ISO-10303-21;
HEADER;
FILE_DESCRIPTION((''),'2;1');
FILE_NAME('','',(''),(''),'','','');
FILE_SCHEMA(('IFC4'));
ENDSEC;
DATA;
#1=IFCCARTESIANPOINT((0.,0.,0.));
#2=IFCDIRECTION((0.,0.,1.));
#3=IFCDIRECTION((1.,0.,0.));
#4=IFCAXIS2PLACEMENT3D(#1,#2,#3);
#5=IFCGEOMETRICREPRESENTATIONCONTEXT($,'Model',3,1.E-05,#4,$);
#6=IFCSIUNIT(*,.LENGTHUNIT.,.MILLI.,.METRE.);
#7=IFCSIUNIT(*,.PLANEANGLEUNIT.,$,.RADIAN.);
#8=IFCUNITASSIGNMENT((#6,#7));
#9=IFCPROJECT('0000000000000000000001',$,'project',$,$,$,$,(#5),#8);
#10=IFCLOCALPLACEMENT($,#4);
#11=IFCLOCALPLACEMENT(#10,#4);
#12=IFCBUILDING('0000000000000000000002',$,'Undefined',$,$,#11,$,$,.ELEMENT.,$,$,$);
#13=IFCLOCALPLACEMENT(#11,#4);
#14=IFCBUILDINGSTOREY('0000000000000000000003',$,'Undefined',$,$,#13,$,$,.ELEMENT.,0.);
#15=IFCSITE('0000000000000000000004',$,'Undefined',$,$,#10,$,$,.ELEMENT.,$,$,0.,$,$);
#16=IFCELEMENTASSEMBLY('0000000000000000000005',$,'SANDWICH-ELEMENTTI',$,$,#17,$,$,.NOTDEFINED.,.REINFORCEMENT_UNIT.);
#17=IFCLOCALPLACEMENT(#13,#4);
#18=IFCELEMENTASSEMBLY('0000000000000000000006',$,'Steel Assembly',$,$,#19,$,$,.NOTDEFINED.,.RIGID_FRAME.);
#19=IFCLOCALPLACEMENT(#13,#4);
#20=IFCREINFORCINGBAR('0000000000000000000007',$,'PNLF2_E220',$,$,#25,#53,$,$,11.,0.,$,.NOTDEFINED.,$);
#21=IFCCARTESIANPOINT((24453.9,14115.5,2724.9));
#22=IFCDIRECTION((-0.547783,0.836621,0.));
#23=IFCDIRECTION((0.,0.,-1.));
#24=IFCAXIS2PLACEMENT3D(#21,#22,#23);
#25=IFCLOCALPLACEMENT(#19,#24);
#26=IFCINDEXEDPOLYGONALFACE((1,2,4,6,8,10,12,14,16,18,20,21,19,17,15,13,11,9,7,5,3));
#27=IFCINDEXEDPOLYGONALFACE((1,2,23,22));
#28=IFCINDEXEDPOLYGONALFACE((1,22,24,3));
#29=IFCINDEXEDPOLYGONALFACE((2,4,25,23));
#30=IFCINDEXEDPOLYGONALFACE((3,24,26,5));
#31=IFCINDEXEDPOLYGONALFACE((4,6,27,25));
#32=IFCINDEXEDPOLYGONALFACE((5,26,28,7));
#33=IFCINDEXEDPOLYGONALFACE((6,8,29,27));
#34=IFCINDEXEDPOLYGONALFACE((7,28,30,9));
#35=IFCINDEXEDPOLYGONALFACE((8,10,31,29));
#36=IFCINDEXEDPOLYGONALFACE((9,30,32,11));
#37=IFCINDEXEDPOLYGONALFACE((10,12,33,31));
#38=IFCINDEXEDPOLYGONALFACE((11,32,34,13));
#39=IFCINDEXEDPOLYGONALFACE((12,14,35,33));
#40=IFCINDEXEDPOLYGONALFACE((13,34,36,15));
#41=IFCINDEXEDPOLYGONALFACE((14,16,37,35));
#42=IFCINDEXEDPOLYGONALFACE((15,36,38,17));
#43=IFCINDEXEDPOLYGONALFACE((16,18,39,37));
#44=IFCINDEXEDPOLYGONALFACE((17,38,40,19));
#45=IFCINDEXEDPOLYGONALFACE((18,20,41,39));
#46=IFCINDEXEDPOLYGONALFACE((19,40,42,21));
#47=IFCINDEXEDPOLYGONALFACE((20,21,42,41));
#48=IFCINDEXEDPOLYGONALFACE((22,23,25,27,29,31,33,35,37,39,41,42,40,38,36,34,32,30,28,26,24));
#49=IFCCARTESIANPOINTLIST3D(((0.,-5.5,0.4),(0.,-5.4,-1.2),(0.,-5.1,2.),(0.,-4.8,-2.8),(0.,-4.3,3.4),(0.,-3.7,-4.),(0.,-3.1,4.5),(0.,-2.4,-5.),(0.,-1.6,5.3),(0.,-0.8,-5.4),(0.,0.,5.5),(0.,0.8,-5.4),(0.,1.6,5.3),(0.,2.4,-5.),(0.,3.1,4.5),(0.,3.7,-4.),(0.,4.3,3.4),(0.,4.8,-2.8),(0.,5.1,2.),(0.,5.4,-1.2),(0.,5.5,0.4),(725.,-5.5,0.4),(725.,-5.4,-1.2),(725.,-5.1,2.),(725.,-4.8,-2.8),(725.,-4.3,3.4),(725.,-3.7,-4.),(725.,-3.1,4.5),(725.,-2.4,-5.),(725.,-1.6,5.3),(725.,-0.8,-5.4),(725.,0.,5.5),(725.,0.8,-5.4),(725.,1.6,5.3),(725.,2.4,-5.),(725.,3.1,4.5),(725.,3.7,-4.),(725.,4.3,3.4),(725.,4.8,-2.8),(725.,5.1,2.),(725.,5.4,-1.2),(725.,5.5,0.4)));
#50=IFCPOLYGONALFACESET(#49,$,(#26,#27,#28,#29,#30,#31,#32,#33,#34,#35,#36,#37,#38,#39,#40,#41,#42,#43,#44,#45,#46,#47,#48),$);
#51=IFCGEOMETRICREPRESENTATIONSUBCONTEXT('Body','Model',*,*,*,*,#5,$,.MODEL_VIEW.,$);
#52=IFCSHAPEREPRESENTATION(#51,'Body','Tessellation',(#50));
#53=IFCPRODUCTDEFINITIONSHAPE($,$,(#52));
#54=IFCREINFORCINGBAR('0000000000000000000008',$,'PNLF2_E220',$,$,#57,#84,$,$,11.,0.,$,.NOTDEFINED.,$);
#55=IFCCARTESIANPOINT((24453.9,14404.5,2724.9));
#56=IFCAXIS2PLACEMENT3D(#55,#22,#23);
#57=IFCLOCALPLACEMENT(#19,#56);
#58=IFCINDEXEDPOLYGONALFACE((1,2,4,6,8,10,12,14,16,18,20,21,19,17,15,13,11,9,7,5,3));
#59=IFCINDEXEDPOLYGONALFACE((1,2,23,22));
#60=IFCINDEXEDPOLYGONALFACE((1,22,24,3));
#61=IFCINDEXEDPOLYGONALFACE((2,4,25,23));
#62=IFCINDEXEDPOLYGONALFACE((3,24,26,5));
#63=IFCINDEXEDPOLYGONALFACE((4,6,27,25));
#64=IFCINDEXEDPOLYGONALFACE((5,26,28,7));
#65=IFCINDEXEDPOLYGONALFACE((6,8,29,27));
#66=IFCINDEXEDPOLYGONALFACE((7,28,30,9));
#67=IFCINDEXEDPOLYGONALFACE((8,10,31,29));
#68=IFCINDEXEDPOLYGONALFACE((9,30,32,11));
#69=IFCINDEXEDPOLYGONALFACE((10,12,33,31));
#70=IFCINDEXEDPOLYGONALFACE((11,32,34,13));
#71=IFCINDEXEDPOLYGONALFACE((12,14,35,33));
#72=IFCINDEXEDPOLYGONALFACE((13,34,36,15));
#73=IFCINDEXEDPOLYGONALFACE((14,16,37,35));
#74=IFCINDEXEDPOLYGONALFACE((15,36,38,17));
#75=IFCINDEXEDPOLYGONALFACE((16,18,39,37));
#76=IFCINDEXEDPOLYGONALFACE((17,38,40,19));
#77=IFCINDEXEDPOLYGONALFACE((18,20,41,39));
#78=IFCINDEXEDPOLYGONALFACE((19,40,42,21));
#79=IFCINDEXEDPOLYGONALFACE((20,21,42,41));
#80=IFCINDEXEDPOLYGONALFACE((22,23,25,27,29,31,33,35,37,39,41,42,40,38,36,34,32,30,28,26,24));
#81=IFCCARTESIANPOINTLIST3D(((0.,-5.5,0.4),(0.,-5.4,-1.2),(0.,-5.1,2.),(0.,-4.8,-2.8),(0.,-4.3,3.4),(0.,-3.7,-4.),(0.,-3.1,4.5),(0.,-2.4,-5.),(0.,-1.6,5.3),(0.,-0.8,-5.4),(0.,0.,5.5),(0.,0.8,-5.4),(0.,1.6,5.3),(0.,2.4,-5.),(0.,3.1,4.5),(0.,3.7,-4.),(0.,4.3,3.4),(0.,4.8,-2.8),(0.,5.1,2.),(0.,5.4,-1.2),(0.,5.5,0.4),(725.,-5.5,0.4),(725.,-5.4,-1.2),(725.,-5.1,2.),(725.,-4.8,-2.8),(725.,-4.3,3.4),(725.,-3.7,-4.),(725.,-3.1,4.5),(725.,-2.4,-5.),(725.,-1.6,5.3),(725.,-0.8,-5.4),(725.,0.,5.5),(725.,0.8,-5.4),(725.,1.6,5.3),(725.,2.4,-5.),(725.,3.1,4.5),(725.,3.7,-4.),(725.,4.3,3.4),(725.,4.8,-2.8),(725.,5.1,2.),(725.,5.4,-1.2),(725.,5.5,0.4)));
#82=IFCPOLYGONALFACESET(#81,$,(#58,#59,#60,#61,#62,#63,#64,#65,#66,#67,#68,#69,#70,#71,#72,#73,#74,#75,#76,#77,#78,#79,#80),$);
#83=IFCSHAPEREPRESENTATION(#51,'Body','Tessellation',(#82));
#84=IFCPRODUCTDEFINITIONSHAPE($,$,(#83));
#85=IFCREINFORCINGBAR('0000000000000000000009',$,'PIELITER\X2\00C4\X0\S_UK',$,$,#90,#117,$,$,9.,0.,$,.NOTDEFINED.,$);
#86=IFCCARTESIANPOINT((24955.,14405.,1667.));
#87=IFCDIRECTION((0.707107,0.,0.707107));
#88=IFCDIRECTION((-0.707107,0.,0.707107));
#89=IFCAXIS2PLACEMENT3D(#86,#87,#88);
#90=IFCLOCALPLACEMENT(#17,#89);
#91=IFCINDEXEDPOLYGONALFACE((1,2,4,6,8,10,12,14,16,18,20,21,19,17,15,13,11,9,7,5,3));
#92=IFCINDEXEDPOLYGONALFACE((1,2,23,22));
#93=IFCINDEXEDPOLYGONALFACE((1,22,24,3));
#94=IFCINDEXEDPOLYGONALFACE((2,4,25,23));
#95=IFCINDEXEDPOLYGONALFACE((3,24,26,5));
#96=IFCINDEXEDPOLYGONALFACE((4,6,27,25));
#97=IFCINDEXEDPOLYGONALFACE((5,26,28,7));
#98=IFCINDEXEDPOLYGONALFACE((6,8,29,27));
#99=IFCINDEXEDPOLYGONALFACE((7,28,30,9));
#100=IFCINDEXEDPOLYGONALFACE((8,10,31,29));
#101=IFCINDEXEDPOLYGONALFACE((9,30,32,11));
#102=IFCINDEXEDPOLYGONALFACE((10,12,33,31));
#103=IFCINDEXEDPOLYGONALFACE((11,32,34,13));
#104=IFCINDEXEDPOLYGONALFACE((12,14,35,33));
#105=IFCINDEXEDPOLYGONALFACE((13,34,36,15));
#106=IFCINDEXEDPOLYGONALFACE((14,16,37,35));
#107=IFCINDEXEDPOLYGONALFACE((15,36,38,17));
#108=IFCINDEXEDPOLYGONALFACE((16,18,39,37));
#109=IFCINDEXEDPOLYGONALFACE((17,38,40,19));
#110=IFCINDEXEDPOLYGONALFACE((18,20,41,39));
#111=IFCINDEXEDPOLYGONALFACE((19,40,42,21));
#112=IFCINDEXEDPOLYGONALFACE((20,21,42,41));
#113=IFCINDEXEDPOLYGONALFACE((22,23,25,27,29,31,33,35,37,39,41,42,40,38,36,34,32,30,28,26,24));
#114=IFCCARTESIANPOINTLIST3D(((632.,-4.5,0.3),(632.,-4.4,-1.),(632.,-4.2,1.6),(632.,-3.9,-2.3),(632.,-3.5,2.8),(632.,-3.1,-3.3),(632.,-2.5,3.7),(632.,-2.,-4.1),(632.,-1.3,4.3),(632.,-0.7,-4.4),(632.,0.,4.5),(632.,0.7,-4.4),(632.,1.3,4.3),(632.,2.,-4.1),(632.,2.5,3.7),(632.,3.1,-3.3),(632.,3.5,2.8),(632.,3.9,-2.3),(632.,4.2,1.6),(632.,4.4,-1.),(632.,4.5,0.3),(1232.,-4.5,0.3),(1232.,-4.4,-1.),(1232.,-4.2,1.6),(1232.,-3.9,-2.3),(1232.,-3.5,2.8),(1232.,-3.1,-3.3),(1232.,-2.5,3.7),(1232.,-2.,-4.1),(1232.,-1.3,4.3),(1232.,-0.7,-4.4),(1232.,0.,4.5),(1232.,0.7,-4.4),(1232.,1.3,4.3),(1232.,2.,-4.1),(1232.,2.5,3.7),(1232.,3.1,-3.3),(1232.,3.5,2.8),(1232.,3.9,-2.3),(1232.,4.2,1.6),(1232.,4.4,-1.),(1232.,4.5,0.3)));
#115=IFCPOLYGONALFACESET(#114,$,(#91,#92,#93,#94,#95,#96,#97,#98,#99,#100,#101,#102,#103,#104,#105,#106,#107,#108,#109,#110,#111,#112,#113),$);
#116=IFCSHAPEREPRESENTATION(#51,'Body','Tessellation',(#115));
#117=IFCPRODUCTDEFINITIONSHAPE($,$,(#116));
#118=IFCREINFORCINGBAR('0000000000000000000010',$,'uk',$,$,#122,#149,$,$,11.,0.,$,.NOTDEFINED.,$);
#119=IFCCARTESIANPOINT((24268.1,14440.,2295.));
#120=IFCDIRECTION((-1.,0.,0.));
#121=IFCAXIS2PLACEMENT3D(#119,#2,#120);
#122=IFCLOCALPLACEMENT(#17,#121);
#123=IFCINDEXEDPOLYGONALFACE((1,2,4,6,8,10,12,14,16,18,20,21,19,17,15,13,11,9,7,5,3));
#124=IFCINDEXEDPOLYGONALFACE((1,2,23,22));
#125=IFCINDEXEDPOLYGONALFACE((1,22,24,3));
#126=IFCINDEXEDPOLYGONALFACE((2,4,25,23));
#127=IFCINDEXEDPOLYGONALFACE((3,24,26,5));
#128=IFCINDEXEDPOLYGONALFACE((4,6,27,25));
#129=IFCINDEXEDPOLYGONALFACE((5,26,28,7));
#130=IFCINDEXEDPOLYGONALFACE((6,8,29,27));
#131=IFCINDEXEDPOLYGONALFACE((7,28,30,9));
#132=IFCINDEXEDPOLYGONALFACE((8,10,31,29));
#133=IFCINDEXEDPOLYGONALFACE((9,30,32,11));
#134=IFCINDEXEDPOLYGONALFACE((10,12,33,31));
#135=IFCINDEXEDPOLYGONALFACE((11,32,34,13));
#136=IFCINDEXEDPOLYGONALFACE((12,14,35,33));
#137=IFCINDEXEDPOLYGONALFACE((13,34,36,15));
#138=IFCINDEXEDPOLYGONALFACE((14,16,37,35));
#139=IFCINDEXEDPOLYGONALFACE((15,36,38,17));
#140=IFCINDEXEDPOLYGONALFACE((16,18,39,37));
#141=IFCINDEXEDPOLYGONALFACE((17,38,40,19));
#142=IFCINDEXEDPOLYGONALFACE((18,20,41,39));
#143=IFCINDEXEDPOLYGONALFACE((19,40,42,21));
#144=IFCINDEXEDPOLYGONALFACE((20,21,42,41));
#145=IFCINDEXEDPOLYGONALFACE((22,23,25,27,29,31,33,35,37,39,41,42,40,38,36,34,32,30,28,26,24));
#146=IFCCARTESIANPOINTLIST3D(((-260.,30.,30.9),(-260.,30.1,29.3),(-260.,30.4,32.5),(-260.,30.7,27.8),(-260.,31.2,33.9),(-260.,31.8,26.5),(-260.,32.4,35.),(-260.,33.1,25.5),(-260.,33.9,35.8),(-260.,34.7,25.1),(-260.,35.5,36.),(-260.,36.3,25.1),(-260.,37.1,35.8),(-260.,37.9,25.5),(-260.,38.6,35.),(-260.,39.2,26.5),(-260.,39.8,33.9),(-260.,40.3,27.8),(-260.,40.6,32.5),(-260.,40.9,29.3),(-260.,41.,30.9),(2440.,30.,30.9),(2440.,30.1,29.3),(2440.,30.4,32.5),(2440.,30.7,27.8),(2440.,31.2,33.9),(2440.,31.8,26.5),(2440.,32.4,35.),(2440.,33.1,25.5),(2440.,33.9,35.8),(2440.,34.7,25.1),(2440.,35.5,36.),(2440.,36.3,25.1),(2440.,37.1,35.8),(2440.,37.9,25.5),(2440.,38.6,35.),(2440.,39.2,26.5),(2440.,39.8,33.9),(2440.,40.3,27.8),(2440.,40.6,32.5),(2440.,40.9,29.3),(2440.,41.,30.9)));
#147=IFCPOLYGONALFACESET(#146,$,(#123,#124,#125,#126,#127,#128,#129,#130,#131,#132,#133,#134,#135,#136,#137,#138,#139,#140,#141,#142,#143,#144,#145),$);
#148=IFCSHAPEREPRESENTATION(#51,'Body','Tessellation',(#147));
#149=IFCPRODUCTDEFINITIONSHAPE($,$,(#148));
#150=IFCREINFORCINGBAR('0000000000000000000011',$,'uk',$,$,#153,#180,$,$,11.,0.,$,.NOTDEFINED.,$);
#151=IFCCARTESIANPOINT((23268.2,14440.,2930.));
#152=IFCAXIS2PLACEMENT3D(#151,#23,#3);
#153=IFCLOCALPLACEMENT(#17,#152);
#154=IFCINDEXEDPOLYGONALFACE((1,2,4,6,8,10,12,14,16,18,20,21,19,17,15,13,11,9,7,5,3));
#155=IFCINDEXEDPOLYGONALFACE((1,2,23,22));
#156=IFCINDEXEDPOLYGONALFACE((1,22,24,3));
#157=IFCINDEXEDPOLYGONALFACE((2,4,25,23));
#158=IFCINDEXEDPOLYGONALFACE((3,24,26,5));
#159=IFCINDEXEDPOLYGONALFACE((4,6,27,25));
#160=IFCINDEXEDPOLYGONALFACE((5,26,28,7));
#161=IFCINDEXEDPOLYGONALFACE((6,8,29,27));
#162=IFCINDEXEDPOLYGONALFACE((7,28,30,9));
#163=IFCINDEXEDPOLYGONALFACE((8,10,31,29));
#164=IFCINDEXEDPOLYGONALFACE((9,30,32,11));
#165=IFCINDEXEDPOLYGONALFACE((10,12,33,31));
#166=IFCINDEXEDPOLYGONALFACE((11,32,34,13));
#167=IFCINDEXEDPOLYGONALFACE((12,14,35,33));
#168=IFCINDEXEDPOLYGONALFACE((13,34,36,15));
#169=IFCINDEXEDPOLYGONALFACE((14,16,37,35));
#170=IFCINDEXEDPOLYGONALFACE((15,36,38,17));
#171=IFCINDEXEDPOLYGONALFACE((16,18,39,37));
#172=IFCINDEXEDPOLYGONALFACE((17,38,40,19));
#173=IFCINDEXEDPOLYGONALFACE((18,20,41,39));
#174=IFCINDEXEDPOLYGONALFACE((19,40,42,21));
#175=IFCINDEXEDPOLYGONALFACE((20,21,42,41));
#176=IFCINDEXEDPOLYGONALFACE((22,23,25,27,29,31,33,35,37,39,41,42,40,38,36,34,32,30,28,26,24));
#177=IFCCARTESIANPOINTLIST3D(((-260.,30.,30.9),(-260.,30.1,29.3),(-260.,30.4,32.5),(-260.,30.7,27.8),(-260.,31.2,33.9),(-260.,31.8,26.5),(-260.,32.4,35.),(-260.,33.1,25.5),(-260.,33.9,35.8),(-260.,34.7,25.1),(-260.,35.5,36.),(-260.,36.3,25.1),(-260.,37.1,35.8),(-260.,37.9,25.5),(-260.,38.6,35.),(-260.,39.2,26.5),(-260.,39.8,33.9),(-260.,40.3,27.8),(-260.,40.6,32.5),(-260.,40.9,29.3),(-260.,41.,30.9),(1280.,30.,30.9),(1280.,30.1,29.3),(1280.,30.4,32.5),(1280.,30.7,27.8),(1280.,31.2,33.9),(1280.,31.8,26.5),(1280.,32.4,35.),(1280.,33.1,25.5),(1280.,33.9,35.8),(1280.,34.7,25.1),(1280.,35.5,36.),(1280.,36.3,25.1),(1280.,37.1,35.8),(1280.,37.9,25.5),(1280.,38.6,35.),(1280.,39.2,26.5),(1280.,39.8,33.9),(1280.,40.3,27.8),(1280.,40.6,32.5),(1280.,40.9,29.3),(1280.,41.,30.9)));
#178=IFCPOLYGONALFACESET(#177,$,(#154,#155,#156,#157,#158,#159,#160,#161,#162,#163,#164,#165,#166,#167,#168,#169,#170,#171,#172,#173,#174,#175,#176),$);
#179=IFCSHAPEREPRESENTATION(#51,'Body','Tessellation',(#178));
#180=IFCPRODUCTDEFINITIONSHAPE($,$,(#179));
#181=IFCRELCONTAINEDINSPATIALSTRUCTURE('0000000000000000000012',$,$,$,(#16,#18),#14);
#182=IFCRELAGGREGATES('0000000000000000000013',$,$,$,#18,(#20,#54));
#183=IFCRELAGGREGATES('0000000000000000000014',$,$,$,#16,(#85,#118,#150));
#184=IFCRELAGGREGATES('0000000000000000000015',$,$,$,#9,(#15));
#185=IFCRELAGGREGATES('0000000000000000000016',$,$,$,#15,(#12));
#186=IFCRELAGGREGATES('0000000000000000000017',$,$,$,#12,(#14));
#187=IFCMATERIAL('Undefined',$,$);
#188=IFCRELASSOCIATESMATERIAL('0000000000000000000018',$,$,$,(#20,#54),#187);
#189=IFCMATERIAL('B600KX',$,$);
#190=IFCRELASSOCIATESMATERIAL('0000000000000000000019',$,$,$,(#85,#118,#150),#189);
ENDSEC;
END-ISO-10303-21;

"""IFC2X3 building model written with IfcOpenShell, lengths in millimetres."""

from ifc_helpers import new_model, entity, si_unit, frame, origin_with_axes, place, context, subcontext, project, spatial, source, transform, mapped, material, element, aggregate, save


model = new_model("IFC2X3")

# Units and contexts
model_context = context("Model", 3, precision=1e-05, world=origin_with_axes())
body_context = subcontext(model_context, "Body", "Model", "MODEL_VIEW")
ifc_project = project(units=[si_unit("LENGTHUNIT", "METRE", prefix="MILLI"), si_unit("PLANEANGLEUNIT", "RADIAN")], contexts=[model_context])

# Site, building, storey
site_placement = place(None, origin_with_axes())
site = spatial("IfcSite", under=ifc_project, at=site_placement, Name="Undefined", CompositionType="ELEMENT", RefElevation=0.0)
building_placement = place(site_placement, origin_with_axes())
building = spatial("IfcBuilding", under=site, at=building_placement, Name="Undefined", CompositionType="ELEMENT")
storey_placement = place(building_placement, origin_with_axes())
storey = spatial("IfcBuildingStorey", under=building, at=storey_placement, Name="Undefined", CompositionType="ELEMENT", Elevation=0.0)

# Element assembly
assembly_1_placement = place(storey_placement, origin_with_axes())
assembly_1 = element("IfcElementAssembly", 1, at=assembly_1_placement, inside=storey, Name="SANDWICH-ELEMENTTI", AssemblyPlace="NOTDEFINED", PredefinedType="REINFORCEMENT_UNIT")

# Element assembly, reinforcing bars
assembly_2_placement = place(storey_placement, origin_with_axes())
assembly_2 = element("IfcElementAssembly", 2, at=assembly_2_placement, inside=storey, Name="Steel Assembly", AssemblyPlace="NOTDEFINED", PredefinedType="RIGID_FRAME")
ifc_material_1 = material(Name="Undefined")
shared_shape_1 = source(origin_with_axes(), body_context, "Body", "AdvancedSweptSolid", [
    entity("IfcSweptDiskSolid", entity("IfcTrimmedCurve", entity("IfcLine", entity("IfcCartesianPoint", [0.0, 0.0, 0.0]), entity("IfcVector", entity("IfcDirection", [1.0, 0.0, 0.0]), 1.0)), [entity("IfcParameterValue", 0.0)], [entity("IfcParameterValue", 725.0)], True, "PARAMETER"), 5.5, None, 0.0, 725.0),
])
reinforcing_bar_1_placement = place(assembly_2_placement, frame((24453.9, 14115.5, 2724.9), z_axis=(-0.547783, 0.836621, 0.0), x_axis=(0.0, 0.0, -1.0)))
reinforcing_bar_1 = element("IfcReinforcingBar", 3, at=reinforcing_bar_1_placement, material=ifc_material_1, Name="PNLF2_E220", BarRole="NOTDEFINED", CrossSectionArea=0.0, NominalDiameter=11.0, context=body_context, shape_type="MappedRepresentation", body=[
    mapped(shared_shape_1, transform((0.0, 0.0, 0.0))),
])
shared_shape_2 = source(origin_with_axes(), body_context, "Body", "AdvancedSweptSolid", [
    entity("IfcSweptDiskSolid", entity("IfcTrimmedCurve", entity("IfcLine", entity("IfcCartesianPoint", [0.0, 0.0, 0.0]), entity("IfcVector", entity("IfcDirection", [1.0, 0.0, 0.0]), 1.0)), [entity("IfcParameterValue", 0.0)], [entity("IfcParameterValue", 725.0)], True, "PARAMETER"), 5.5, None, 0.0, 725.0),
])
reinforcing_bar_2_placement = place(assembly_2_placement, frame((24453.9, 14404.5, 2724.9), z_axis=(-0.547783, 0.836621, 0.0), x_axis=(0.0, 0.0, -1.0)))
reinforcing_bar_2 = element("IfcReinforcingBar", 4, at=reinforcing_bar_2_placement, material=ifc_material_1, Name="PNLF2_E220", BarRole="NOTDEFINED", CrossSectionArea=0.0, NominalDiameter=11.0, context=body_context, shape_type="MappedRepresentation", body=[
    mapped(shared_shape_2, transform((0.0, 0.0, 0.0))),
])
aggregate(assembly_2, [reinforcing_bar_1, reinforcing_bar_2])

# Reinforcing bars
ifc_material_2 = material(Name="B600KX")
shared_shape_3 = source(origin_with_axes(), body_context, "Body", "AdvancedSweptSolid", [
    entity("IfcSweptDiskSolid", entity("IfcTrimmedCurve", entity("IfcLine", entity("IfcCartesianPoint", [0.0, 0.0, 0.0]), entity("IfcVector", entity("IfcDirection", [1.0, 0.0, 0.0]), 1.0)), [entity("IfcParameterValue", 0.0)], [entity("IfcParameterValue", 600.0)], True, "PARAMETER"), 4.5, None, 0.0, 600.0),
])
reinforcing_bar_3_placement = place(assembly_1_placement, frame((24955.0, 14405.0, 1667.0), z_axis=(0.707107, 0.0, 0.707107), x_axis=(-0.707107, 0.0, 0.707107)))
reinforcing_bar_3 = element("IfcReinforcingBar", 5, at=reinforcing_bar_3_placement, material=ifc_material_2, Name="PIELITERÄS_UK", BarRole="NOTDEFINED", CrossSectionArea=0.0, NominalDiameter=9.0, context=body_context, shape_type="MappedRepresentation", body=[
    mapped(shared_shape_3, transform((632.0, 0.0, 0.0))),
])
shared_shape_4 = source(origin_with_axes(), body_context, "Body", "AdvancedSweptSolid", [
    entity("IfcSweptDiskSolid", entity("IfcTrimmedCurve", entity("IfcLine", entity("IfcCartesianPoint", [0.0, 0.0, 0.0]), entity("IfcVector", entity("IfcDirection", [1.0, 0.0, 0.0]), 1.0)), [entity("IfcParameterValue", 0.0)], [entity("IfcParameterValue", 2699.9999)], True, "PARAMETER"), 5.5, None, 0.0, 2700.0),
])
reinforcing_bar_4_placement = place(assembly_1_placement, frame((24268.1, 14440.0, 2295.0), z_axis=(0.0, 0.0, 1.0), x_axis=(-1.0, 0.0, 0.0)))
reinforcing_bar_4 = element("IfcReinforcingBar", 6, at=reinforcing_bar_4_placement, material=ifc_material_2, Name="uk", BarRole="NOTDEFINED", CrossSectionArea=0.0, NominalDiameter=11.0, context=body_context, shape_type="MappedRepresentation", body=[
    mapped(shared_shape_4, transform((-260.0, 35.5, 30.5))),
])
shared_shape_5 = source(origin_with_axes(), body_context, "Body", "AdvancedSweptSolid", [
    entity("IfcSweptDiskSolid", entity("IfcTrimmedCurve", entity("IfcLine", entity("IfcCartesianPoint", [0.0, 0.0, 0.0]), entity("IfcVector", entity("IfcDirection", [1.0, 0.0, 0.0]), 1.0)), [entity("IfcParameterValue", 0.0)], [entity("IfcParameterValue", 1540.0001)], True, "PARAMETER"), 5.5, None, 0.0, 1540.0),
])
reinforcing_bar_5_placement = place(assembly_1_placement, frame((23268.2, 14440.0, 2930.0), z_axis=(0.0, 0.0, -1.0), x_axis=(1.0, 0.0, 0.0)))
reinforcing_bar_5 = element("IfcReinforcingBar", 7, at=reinforcing_bar_5_placement, material=ifc_material_2, Name="uk", BarRole="NOTDEFINED", CrossSectionArea=0.0, NominalDiameter=11.0, context=body_context, shape_type="MappedRepresentation", body=[
    mapped(shared_shape_5, transform((-260.0, 35.5, 30.5))),
])
aggregate(assembly_1, [reinforcing_bar_3, reinforcing_bar_4, reinforcing_bar_5])

save(model, "model.ifc")
